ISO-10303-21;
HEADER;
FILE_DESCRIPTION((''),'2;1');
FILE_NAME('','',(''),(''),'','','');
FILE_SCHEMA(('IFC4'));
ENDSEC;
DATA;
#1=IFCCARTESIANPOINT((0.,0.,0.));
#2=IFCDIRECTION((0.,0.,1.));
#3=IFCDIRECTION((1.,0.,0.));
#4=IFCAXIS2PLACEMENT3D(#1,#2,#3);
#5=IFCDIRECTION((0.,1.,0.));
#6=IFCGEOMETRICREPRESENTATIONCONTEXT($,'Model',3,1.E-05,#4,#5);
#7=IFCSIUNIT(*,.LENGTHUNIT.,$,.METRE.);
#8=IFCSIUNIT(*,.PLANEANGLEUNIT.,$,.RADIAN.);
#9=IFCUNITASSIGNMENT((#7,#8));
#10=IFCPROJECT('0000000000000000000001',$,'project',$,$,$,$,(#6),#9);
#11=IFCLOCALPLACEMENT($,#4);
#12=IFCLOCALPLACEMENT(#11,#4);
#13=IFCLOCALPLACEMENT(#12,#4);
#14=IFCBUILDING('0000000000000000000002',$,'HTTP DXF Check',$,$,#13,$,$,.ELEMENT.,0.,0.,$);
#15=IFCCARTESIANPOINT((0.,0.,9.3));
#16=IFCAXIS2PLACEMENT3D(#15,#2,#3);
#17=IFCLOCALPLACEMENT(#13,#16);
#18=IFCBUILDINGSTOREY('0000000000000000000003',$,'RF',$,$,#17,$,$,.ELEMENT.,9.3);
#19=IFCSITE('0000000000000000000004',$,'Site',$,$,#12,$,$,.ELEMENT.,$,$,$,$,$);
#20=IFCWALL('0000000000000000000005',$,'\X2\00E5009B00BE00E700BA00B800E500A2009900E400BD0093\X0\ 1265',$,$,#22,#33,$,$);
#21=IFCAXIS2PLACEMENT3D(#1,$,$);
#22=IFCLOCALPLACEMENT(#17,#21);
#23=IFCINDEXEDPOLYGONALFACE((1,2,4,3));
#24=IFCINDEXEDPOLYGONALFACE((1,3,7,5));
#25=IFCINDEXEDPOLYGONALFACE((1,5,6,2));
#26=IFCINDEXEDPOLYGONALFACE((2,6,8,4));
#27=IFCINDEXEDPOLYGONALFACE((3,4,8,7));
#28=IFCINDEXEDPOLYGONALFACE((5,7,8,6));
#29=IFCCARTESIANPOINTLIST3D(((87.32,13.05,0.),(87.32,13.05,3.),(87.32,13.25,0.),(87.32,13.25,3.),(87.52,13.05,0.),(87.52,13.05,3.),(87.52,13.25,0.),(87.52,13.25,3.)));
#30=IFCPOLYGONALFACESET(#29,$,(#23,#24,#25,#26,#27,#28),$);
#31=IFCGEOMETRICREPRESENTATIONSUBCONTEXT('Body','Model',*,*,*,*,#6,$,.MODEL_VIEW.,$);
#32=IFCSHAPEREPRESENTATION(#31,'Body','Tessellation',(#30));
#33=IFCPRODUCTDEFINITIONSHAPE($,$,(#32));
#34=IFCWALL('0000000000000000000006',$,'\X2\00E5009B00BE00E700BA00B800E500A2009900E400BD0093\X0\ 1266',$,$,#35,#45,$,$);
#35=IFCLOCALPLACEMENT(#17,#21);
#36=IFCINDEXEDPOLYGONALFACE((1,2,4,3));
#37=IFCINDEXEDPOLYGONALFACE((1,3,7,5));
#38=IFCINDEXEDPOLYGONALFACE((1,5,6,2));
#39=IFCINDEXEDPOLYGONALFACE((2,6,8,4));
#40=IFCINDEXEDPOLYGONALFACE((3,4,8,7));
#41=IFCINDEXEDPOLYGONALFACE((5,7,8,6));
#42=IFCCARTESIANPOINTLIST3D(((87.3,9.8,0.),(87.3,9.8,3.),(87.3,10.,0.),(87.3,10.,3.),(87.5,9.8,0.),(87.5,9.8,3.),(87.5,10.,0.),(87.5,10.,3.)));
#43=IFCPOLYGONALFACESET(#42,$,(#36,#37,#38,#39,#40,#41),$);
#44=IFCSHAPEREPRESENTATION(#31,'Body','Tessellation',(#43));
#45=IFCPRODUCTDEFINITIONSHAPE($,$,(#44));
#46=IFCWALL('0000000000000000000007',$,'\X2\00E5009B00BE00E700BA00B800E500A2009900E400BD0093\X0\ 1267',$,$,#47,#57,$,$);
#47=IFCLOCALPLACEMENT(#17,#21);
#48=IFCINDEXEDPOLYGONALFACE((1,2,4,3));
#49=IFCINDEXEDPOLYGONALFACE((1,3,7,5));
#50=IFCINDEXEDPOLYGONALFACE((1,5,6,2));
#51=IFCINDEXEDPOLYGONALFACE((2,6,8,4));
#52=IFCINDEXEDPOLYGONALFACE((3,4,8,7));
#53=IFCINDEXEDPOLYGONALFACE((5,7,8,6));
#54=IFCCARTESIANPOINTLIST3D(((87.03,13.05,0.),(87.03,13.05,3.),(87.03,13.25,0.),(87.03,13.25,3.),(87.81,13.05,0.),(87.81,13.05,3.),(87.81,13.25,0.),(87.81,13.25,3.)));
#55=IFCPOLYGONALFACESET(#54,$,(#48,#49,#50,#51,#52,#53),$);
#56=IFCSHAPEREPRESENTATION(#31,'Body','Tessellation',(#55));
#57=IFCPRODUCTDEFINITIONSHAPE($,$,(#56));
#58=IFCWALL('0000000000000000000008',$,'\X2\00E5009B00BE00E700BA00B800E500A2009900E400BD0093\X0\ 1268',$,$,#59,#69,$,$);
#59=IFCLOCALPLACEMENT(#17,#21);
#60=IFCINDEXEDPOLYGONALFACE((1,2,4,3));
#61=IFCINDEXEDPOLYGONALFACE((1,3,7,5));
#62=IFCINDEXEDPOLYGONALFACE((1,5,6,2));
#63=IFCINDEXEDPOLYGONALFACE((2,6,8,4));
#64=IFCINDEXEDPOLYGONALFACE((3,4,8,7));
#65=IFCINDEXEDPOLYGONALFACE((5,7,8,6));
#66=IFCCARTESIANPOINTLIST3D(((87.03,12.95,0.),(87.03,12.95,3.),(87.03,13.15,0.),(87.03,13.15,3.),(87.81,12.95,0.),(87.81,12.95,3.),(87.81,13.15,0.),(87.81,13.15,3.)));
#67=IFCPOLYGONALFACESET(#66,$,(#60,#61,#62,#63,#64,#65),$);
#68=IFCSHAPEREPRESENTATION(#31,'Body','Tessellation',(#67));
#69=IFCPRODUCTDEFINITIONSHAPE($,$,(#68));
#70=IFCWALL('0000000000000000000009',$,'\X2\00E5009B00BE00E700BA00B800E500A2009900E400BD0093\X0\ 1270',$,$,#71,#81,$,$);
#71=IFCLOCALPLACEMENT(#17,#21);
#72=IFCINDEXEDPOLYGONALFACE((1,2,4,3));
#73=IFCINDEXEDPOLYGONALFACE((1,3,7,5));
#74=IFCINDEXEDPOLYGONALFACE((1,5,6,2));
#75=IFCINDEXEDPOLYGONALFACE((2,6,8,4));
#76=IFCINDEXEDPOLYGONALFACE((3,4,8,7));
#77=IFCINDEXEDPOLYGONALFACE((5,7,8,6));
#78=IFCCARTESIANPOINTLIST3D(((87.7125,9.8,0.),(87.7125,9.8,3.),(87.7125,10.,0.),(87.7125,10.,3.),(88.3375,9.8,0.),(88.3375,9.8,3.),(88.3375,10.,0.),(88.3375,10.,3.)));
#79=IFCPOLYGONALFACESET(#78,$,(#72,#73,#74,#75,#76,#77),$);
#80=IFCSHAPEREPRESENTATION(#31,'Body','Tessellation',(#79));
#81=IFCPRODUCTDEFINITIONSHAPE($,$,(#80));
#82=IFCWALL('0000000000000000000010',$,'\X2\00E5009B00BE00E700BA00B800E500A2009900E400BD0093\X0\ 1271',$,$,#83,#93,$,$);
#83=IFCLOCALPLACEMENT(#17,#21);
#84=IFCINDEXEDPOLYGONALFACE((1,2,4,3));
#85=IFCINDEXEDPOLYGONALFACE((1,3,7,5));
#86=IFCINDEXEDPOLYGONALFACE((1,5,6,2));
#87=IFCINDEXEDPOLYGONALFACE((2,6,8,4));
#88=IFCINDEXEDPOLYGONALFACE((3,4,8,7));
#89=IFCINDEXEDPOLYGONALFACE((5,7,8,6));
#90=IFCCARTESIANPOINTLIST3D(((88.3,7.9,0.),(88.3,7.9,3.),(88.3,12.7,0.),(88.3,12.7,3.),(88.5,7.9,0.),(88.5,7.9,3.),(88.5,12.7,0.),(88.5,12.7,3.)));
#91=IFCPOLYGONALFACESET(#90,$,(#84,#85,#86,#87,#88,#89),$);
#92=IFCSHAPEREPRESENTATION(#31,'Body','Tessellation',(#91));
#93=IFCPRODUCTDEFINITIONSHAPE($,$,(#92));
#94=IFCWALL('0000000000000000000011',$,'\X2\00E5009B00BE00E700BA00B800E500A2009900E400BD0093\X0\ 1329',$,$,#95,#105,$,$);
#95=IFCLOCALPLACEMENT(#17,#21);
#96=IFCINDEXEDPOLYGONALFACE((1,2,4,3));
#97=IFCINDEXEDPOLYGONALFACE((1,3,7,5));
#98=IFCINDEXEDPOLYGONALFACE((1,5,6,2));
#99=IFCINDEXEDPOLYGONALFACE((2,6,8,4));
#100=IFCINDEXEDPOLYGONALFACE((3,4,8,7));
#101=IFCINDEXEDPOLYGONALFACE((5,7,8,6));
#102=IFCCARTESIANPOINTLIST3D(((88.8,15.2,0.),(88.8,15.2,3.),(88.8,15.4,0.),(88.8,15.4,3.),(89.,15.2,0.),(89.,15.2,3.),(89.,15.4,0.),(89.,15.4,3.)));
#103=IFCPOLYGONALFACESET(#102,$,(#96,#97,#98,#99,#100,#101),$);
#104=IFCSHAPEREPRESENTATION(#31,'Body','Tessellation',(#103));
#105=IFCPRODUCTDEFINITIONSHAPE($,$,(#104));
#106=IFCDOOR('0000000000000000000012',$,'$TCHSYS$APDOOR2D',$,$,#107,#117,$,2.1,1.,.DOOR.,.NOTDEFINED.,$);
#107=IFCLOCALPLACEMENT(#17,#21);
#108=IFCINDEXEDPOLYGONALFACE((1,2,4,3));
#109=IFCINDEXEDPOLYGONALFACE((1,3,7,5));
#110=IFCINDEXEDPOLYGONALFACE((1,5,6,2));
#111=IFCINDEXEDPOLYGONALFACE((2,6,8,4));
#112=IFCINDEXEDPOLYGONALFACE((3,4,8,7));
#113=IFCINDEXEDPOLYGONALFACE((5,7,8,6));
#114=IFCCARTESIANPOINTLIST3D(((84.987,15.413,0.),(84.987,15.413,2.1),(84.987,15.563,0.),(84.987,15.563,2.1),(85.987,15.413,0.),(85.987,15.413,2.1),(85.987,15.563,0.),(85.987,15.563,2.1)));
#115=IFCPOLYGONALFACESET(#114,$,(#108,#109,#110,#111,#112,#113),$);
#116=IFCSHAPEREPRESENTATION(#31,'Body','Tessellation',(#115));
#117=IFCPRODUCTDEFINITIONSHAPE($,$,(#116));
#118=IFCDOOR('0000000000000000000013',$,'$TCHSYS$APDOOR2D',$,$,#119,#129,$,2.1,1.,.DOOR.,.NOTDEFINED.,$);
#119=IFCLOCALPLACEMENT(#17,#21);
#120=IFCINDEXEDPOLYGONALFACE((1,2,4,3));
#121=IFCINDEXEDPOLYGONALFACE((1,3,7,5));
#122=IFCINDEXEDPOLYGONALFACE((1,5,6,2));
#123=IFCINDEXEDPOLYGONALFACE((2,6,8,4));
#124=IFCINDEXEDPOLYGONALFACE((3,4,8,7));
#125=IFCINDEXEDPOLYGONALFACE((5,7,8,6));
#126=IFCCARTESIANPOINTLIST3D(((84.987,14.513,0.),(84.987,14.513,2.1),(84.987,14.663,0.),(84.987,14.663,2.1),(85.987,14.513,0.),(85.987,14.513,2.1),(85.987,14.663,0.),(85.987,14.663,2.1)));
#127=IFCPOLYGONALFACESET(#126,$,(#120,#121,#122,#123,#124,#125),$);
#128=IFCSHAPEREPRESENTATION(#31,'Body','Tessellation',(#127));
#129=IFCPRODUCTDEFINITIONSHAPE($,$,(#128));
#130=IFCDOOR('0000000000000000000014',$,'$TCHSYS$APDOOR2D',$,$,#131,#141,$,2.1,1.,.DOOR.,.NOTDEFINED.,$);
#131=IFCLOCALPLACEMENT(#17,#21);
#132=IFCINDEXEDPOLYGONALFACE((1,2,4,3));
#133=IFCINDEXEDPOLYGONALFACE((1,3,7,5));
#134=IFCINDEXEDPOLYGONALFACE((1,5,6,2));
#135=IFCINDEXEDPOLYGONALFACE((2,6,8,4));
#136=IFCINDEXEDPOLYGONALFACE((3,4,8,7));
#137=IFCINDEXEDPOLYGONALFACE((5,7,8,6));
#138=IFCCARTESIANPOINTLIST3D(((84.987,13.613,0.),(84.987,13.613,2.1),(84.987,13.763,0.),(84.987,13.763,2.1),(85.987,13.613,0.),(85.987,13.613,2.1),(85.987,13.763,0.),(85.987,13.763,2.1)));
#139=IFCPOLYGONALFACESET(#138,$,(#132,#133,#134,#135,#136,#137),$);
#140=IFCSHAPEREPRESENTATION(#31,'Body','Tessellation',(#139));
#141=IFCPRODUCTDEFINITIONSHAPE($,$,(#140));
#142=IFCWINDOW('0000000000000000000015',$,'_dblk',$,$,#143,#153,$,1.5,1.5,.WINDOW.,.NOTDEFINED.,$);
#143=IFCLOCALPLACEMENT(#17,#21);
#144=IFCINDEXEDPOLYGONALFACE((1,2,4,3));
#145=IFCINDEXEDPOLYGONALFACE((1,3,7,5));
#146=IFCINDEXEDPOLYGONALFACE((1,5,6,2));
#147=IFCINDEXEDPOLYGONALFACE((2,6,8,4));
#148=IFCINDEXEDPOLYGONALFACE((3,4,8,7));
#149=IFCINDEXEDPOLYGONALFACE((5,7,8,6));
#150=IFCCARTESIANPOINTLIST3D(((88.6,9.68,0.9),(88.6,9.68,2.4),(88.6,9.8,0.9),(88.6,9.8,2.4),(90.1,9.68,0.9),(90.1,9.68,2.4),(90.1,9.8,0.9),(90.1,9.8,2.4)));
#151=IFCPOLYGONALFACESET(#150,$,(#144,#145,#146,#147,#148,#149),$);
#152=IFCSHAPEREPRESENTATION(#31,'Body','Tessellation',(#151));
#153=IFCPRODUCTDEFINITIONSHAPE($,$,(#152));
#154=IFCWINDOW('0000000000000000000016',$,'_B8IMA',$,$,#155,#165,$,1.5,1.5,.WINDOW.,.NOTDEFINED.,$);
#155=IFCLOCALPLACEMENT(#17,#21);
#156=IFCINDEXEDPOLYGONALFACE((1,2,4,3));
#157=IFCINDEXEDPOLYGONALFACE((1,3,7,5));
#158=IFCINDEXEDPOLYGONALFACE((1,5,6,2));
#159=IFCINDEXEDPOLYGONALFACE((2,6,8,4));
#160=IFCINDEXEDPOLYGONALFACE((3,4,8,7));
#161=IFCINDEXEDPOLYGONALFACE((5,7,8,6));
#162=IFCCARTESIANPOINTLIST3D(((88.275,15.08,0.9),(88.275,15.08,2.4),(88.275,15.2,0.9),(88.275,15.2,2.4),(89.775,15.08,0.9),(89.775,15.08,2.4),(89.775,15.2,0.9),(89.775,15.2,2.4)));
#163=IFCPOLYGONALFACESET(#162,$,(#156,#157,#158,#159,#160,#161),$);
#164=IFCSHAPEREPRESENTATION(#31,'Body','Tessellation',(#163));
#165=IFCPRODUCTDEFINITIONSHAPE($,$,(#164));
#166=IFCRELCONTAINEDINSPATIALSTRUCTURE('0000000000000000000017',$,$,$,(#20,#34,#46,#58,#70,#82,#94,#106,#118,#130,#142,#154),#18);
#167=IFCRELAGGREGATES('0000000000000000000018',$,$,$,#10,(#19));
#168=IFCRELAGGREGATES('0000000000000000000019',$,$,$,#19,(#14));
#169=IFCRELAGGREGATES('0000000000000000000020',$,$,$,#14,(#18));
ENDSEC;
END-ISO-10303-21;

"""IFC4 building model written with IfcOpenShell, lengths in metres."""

from ifc_helpers import new_model, si_unit, direction, frame, frame_2d, origin_with_axes, place, context, subcontext, project, spatial, rectangle, extrude, element, save


model = new_model("IFC4")

# Units and contexts
model_context = context("Model", 3, precision=1e-05, world=origin_with_axes(), true_north=direction((0.0, 1.0, 0.0)))
body_context = subcontext(model_context, "Body", "Model", "MODEL_VIEW")
ifc_project = project(units=[si_unit("LENGTHUNIT", "METRE"), si_unit("PLANEANGLEUNIT", "RADIAN")], contexts=[model_context])

# Site, building, storey
placement = place(None, origin_with_axes())
site_placement = place(placement, origin_with_axes())
site = spatial("IfcSite", under=ifc_project, at=site_placement, Name="Site", CompositionType="ELEMENT")
building_placement = place(site_placement, origin_with_axes())
building = spatial("IfcBuilding", under=site, at=building_placement, Name="HTTP DXF Check", CompositionType="ELEMENT", ElevationOfRefHeight=0.0, ElevationOfTerrain=0.0)
storey_placement = place(building_placement, frame((0.0, 0.0, 9.3), z_axis=(0.0, 0.0, 1.0), x_axis=(1.0, 0.0, 0.0)))
storey = spatial("IfcBuildingStorey", under=building, at=storey_placement, Name="RF", CompositionType="ELEMENT", Elevation=9.3)

# Walls
for number, where, z_axis, x_axis, name in (
    (1, (87.42, 13.15, 0.0), (0.0, 0.0, 1.0), (0.0, -1.0, 0.0), "å\u009b¾çº¸å¢\u0099ä½\u0093 1265"),
    (2, (87.4, 9.9, 0.0), (0.0, 0.0, 1.0), (0.0, -1.0, 0.0), "å\u009b¾çº¸å¢\u0099ä½\u0093 1266"),
):
    element("IfcWall", number, at=place(storey_placement, frame(where, z_axis=z_axis, x_axis=x_axis)), inside=storey, Name=name, context=body_context, shape_type="SweptSolid", body=[
        extrude(rectangle(XDim=0.2, YDim=0.2, at=frame_2d((0.0, 0.0), x_axis=(1.0, 0.0, 0.0))), frame((0.0, 0.0, 0.0), z_axis=(0.0, 0.0, 1.0)), (0.0, 0.0, 1.0), 3.0),
    ])
for number, where, z_axis, x_axis, name in (
    (3, (87.42, 13.15, 0.0), (0.0, 0.0, 1.0), (1.0, 0.0, 0.0), "å\u009b¾çº¸å¢\u0099ä½\u0093 1267"),
    (4, (87.42, 13.05, 0.0), (0.0, 0.0, 1.0), (1.0, 0.0, 0.0), "å\u009b¾çº¸å¢\u0099ä½\u0093 1268"),
):
    element("IfcWall", number, at=place(storey_placement, frame(where, z_axis=z_axis, x_axis=x_axis)), inside=storey, Name=name, context=body_context, shape_type="SweptSolid", body=[
        extrude(rectangle(XDim=0.78, YDim=0.2, at=frame_2d((0.0, 0.0), x_axis=(1.0, 0.0, 0.0))), frame((0.0, 0.0, 0.0), z_axis=(0.0, 0.0, 1.0)), (0.0, 0.0, 1.0), 3.0),
    ])
wall_1_placement = place(storey_placement, frame((88.025, 9.9, 0.0), z_axis=(0.0, 0.0, 1.0), x_axis=(-1.0, 0.0, 0.0)))
element("IfcWall", 5, at=wall_1_placement, inside=storey, Name="å\u009b¾çº¸å¢\u0099ä½\u0093 1270", context=body_context, shape_type="SweptSolid", body=[
    extrude(rectangle(XDim=0.625, YDim=0.2, at=frame_2d((0.0, 0.0), x_axis=(1.0, 0.0, 0.0))), frame((0.0, 0.0, 0.0), z_axis=(0.0, 0.0, 1.0)), (0.0, 0.0, 1.0), 3.0),
])
wall_2_placement = place(storey_placement, frame((88.4, 10.3, 0.0), z_axis=(0.0, 0.0, 1.0), x_axis=(0.0, 1.0, 0.0)))
element("IfcWall", 6, at=wall_2_placement, inside=storey, Name="å\u009b¾çº¸å¢\u0099ä½\u0093 1271", context=body_context, shape_type="SweptSolid", body=[
    extrude(rectangle(XDim=4.8, YDim=0.2, at=frame_2d((0.0, 0.0), x_axis=(1.0, 0.0, 0.0))), frame((0.0, 0.0, 0.0), z_axis=(0.0, 0.0, 1.0)), (0.0, 0.0, 1.0), 3.0),
])
wall_3_placement = place(storey_placement, frame((88.9, 15.3, 0.0), z_axis=(0.0, 0.0, 1.0), x_axis=(0.0, -1.0, 0.0)))
element("IfcWall", 7, at=wall_3_placement, inside=storey, Name="å\u009b¾çº¸å¢\u0099ä½\u0093 1329", context=body_context, shape_type="SweptSolid", body=[
    extrude(rectangle(XDim=0.2, YDim=0.2, at=frame_2d((0.0, 0.0), x_axis=(1.0, 0.0, 0.0))), frame((0.0, 0.0, 0.0), z_axis=(0.0, 0.0, 1.0)), (0.0, 0.0, 1.0), 3.0),
])

# Doors
for number, where, z_axis, x_axis, name in (
    (8, (85.487, 15.488, 0.0), (0.0, 0.0, 1.0), (1.0, 0.0, 0.0), "$TCHSYS$APDOOR2D"),
    (9, (85.487, 14.588, 0.0), (0.0, 0.0, 1.0), (1.0, 0.0, 0.0), "$TCHSYS$APDOOR2D"),
    (10, (85.487, 13.688, 0.0), (0.0, 0.0, 1.0), (1.0, 0.0, 0.0), "$TCHSYS$APDOOR2D"),
):
    element("IfcDoor", number, at=place(storey_placement, frame(where, z_axis=z_axis, x_axis=x_axis)), inside=storey, Name=name, OperationType="NOTDEFINED", OverallHeight=2.1, OverallWidth=1.0, PredefinedType="DOOR", context=body_context, shape_type="SweptSolid", body=[
        extrude(rectangle(XDim=1.0, YDim=0.15, at=frame_2d((0.0, 0.0), x_axis=(1.0, 0.0, 0.0))), frame((0.0, 0.0, 0.0), z_axis=(0.0, 0.0, 1.0)), (0.0, 0.0, 1.0), 2.1),
    ])

# Windows
for number, where, z_axis, x_axis, name in (
    (11, (89.35, 9.74, 0.9), (0.0, 0.0, 1.0), (1.0, 0.0, 0.0), "_dblk"),
    (12, (89.025, 15.14, 0.9), (0.0, 0.0, 1.0), (1.0, 0.0, 0.0), "_B8IMA"),
):
    element("IfcWindow", number, at=place(storey_placement, frame(where, z_axis=z_axis, x_axis=x_axis)), inside=storey, Name=name, OverallHeight=1.5, OverallWidth=1.5, PartitioningType="NOTDEFINED", PredefinedType="WINDOW", context=body_context, shape_type="SweptSolid", body=[
        extrude(rectangle(XDim=1.5, YDim=0.12, at=frame_2d((0.0, 0.0), x_axis=(1.0, 0.0, 0.0))), frame((0.0, 0.0, 0.0), z_axis=(0.0, 0.0, 1.0)), (0.0, 0.0, 1.0), 1.5),
    ])

save(model, "model.ifc")
